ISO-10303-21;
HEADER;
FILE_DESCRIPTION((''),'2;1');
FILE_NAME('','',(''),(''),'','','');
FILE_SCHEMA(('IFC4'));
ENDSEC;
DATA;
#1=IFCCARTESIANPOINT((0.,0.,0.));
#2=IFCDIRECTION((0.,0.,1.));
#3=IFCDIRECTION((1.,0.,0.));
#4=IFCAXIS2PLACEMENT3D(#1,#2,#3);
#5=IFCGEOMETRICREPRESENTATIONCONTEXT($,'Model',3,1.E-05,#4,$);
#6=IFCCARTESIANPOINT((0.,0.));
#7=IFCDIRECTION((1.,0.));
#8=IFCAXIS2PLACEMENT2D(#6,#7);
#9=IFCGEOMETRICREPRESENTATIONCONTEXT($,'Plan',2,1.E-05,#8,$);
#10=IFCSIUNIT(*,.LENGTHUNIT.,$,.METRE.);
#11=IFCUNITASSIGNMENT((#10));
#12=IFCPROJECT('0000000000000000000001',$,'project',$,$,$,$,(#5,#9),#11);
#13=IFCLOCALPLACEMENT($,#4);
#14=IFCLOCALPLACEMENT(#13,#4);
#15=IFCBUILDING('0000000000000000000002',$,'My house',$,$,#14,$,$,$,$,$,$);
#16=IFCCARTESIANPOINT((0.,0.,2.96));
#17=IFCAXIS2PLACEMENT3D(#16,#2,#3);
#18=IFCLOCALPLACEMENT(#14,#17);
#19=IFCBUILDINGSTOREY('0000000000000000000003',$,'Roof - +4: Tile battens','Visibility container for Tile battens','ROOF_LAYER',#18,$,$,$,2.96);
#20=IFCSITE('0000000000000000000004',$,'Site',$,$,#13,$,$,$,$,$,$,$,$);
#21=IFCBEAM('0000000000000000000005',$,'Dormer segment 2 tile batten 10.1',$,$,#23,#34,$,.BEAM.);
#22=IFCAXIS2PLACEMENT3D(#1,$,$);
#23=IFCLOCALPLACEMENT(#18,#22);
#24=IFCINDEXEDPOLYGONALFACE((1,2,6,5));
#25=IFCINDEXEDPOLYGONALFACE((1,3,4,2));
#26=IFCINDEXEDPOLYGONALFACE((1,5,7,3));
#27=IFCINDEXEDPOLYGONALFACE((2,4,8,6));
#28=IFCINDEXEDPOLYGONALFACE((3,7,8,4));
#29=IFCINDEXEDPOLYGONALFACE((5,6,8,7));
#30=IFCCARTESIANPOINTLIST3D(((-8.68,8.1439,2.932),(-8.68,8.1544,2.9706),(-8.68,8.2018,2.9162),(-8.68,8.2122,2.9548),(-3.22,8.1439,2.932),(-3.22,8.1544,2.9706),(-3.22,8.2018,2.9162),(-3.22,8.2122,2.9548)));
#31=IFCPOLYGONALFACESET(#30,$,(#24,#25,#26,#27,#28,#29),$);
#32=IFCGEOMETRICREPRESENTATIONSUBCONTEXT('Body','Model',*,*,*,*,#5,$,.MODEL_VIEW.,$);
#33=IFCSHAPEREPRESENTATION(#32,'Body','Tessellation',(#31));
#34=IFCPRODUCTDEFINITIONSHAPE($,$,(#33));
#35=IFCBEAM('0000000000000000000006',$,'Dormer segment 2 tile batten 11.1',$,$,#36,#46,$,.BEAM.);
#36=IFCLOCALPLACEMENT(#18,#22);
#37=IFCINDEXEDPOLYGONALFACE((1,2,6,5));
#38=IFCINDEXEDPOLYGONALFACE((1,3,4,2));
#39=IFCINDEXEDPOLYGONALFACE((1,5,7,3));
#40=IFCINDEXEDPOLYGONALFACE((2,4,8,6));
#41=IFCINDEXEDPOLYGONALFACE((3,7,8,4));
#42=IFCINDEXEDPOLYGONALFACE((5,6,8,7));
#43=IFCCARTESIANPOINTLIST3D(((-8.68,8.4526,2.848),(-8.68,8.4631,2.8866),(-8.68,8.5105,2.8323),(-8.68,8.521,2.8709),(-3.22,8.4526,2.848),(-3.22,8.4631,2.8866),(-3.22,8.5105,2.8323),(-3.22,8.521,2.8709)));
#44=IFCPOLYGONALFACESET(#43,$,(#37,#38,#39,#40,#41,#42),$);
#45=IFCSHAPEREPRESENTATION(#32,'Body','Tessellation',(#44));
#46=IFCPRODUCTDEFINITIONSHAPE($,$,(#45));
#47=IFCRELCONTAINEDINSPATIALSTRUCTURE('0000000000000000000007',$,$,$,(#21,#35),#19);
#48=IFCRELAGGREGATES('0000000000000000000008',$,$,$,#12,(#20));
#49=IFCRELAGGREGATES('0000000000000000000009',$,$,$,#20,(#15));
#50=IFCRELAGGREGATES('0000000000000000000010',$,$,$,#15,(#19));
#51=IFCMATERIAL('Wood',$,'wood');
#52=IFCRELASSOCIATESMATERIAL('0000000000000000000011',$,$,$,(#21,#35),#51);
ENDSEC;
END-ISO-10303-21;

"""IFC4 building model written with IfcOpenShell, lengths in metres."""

from ifc_helpers import new_model, si_unit, frame, origin_with_axes, origin_2d_with_axis, place, context, subcontext, project, spatial, rectangle, extrude, clip, halfspace, source, transform, mapped, material, element, save


model = new_model("IFC4")

# Units and contexts
model_context = context("Model", 3, precision=1e-05, world=origin_with_axes())
plan_context = context("Plan", 2, precision=1e-05, world=origin_2d_with_axis())
body_context = subcontext(model_context, "Body", "Model", "MODEL_VIEW")
ifc_project = project(units=[si_unit("LENGTHUNIT", "METRE")], contexts=[model_context, plan_context])

# Site, building, storey
site_placement = place(None, origin_with_axes())
site = spatial("IfcSite", under=ifc_project, at=site_placement, Name="Site")
building_placement = place(site_placement, origin_with_axes())
building = spatial("IfcBuilding", under=site, at=building_placement, Name="My house")
storey_placement = place(building_placement, frame((0.0, 0.0, 2.96), z_axis=(0.0, 0.0, 1.0), x_axis=(1.0, 0.0, 0.0)))
storey = spatial("IfcBuildingStorey", under=building, at=storey_placement, Name="Roof - +4: Tile battens", Description="Visibility container for Tile battens", ObjectType="ROOF_LAYER", Elevation=2.96)

# Beams
ifc_material = material(Name="Wood", Category="wood")
shared_shape_1 = source(origin_with_axes(), body_context, "Body", "Clipping", [
    clip(clip(extrude(rectangle(XDim=0.06, YDim=0.04), frame((0.0, 0.0, 0.0), z_axis=(1.0, 0.0, 0.0), x_axis=(0.0, 1.0, 0.0)), (0.0, 0.0, 1.0), 5.46), halfspace(frame((-3.22, -2.4823, -6.793), z_axis=(0.0, -0.964948, -0.262441), x_axis=(-1.0, 0.0, 0.0)), False)), halfspace(frame((-3.22, 2.1012, -5.5464), z_axis=(0.0, 0.964948, 0.262441), x_axis=(1.0, 0.0, 0.0)), False)),
])
beam_1_placement = place(storey_placement, frame((-3.22, 8.1781, 2.9434), z_axis=(0.0, 0.262441, 0.964948), x_axis=(1.0, 0.0, 0.0)))
element("IfcBeam", 1, at=beam_1_placement, inside=storey, material=ifc_material, Name="Dormer segment 2 tile batten 10.1", PredefinedType="BEAM", context=body_context, shape_type="MappedRepresentation", body=[
    mapped(shared_shape_1, transform((0.0, 0.0, 0.0), x_axis=(-1.0, 0.0, 0.0), y_axis=(0.0, 1.0, 0.0), z_axis=(0.0, 0.0, 1.0), scale=1.0)),
])
shared_shape_2 = source(origin_with_axes(), body_context, "Body", "Clipping", [
    clip(clip(extrude(rectangle(XDim=0.06, YDim=0.04), frame((0.0, 0.0, 0.0), z_axis=(1.0, 0.0, 0.0), x_axis=(0.0, 1.0, 0.0)), (0.0, 0.0, 1.0), 5.46), halfspace(frame((-3.22, -2.8023, -6.793), z_axis=(0.0, -0.964948, -0.262441), x_axis=(-1.0, 0.0, 0.0)), False)), halfspace(frame((-3.22, 1.7812, -5.5464), z_axis=(0.0, 0.964948, 0.262441), x_axis=(1.0, 0.0, 0.0)), False)),
])
beam_2_placement = place(storey_placement, frame((-3.22, 8.4868, 2.8594), z_axis=(0.0, 0.262441, 0.964948), x_axis=(1.0, 0.0, 0.0)))
element("IfcBeam", 2, at=beam_2_placement, inside=storey, material=ifc_material, Name="Dormer segment 2 tile batten 11.1", PredefinedType="BEAM", context=body_context, shape_type="MappedRepresentation", body=[
    mapped(shared_shape_2, transform((0.0, 0.0, 0.0), x_axis=(-1.0, 0.0, 0.0), y_axis=(0.0, 1.0, 0.0), z_axis=(0.0, 0.0, 1.0), scale=1.0)),
])

save(model, "model.ifc")
